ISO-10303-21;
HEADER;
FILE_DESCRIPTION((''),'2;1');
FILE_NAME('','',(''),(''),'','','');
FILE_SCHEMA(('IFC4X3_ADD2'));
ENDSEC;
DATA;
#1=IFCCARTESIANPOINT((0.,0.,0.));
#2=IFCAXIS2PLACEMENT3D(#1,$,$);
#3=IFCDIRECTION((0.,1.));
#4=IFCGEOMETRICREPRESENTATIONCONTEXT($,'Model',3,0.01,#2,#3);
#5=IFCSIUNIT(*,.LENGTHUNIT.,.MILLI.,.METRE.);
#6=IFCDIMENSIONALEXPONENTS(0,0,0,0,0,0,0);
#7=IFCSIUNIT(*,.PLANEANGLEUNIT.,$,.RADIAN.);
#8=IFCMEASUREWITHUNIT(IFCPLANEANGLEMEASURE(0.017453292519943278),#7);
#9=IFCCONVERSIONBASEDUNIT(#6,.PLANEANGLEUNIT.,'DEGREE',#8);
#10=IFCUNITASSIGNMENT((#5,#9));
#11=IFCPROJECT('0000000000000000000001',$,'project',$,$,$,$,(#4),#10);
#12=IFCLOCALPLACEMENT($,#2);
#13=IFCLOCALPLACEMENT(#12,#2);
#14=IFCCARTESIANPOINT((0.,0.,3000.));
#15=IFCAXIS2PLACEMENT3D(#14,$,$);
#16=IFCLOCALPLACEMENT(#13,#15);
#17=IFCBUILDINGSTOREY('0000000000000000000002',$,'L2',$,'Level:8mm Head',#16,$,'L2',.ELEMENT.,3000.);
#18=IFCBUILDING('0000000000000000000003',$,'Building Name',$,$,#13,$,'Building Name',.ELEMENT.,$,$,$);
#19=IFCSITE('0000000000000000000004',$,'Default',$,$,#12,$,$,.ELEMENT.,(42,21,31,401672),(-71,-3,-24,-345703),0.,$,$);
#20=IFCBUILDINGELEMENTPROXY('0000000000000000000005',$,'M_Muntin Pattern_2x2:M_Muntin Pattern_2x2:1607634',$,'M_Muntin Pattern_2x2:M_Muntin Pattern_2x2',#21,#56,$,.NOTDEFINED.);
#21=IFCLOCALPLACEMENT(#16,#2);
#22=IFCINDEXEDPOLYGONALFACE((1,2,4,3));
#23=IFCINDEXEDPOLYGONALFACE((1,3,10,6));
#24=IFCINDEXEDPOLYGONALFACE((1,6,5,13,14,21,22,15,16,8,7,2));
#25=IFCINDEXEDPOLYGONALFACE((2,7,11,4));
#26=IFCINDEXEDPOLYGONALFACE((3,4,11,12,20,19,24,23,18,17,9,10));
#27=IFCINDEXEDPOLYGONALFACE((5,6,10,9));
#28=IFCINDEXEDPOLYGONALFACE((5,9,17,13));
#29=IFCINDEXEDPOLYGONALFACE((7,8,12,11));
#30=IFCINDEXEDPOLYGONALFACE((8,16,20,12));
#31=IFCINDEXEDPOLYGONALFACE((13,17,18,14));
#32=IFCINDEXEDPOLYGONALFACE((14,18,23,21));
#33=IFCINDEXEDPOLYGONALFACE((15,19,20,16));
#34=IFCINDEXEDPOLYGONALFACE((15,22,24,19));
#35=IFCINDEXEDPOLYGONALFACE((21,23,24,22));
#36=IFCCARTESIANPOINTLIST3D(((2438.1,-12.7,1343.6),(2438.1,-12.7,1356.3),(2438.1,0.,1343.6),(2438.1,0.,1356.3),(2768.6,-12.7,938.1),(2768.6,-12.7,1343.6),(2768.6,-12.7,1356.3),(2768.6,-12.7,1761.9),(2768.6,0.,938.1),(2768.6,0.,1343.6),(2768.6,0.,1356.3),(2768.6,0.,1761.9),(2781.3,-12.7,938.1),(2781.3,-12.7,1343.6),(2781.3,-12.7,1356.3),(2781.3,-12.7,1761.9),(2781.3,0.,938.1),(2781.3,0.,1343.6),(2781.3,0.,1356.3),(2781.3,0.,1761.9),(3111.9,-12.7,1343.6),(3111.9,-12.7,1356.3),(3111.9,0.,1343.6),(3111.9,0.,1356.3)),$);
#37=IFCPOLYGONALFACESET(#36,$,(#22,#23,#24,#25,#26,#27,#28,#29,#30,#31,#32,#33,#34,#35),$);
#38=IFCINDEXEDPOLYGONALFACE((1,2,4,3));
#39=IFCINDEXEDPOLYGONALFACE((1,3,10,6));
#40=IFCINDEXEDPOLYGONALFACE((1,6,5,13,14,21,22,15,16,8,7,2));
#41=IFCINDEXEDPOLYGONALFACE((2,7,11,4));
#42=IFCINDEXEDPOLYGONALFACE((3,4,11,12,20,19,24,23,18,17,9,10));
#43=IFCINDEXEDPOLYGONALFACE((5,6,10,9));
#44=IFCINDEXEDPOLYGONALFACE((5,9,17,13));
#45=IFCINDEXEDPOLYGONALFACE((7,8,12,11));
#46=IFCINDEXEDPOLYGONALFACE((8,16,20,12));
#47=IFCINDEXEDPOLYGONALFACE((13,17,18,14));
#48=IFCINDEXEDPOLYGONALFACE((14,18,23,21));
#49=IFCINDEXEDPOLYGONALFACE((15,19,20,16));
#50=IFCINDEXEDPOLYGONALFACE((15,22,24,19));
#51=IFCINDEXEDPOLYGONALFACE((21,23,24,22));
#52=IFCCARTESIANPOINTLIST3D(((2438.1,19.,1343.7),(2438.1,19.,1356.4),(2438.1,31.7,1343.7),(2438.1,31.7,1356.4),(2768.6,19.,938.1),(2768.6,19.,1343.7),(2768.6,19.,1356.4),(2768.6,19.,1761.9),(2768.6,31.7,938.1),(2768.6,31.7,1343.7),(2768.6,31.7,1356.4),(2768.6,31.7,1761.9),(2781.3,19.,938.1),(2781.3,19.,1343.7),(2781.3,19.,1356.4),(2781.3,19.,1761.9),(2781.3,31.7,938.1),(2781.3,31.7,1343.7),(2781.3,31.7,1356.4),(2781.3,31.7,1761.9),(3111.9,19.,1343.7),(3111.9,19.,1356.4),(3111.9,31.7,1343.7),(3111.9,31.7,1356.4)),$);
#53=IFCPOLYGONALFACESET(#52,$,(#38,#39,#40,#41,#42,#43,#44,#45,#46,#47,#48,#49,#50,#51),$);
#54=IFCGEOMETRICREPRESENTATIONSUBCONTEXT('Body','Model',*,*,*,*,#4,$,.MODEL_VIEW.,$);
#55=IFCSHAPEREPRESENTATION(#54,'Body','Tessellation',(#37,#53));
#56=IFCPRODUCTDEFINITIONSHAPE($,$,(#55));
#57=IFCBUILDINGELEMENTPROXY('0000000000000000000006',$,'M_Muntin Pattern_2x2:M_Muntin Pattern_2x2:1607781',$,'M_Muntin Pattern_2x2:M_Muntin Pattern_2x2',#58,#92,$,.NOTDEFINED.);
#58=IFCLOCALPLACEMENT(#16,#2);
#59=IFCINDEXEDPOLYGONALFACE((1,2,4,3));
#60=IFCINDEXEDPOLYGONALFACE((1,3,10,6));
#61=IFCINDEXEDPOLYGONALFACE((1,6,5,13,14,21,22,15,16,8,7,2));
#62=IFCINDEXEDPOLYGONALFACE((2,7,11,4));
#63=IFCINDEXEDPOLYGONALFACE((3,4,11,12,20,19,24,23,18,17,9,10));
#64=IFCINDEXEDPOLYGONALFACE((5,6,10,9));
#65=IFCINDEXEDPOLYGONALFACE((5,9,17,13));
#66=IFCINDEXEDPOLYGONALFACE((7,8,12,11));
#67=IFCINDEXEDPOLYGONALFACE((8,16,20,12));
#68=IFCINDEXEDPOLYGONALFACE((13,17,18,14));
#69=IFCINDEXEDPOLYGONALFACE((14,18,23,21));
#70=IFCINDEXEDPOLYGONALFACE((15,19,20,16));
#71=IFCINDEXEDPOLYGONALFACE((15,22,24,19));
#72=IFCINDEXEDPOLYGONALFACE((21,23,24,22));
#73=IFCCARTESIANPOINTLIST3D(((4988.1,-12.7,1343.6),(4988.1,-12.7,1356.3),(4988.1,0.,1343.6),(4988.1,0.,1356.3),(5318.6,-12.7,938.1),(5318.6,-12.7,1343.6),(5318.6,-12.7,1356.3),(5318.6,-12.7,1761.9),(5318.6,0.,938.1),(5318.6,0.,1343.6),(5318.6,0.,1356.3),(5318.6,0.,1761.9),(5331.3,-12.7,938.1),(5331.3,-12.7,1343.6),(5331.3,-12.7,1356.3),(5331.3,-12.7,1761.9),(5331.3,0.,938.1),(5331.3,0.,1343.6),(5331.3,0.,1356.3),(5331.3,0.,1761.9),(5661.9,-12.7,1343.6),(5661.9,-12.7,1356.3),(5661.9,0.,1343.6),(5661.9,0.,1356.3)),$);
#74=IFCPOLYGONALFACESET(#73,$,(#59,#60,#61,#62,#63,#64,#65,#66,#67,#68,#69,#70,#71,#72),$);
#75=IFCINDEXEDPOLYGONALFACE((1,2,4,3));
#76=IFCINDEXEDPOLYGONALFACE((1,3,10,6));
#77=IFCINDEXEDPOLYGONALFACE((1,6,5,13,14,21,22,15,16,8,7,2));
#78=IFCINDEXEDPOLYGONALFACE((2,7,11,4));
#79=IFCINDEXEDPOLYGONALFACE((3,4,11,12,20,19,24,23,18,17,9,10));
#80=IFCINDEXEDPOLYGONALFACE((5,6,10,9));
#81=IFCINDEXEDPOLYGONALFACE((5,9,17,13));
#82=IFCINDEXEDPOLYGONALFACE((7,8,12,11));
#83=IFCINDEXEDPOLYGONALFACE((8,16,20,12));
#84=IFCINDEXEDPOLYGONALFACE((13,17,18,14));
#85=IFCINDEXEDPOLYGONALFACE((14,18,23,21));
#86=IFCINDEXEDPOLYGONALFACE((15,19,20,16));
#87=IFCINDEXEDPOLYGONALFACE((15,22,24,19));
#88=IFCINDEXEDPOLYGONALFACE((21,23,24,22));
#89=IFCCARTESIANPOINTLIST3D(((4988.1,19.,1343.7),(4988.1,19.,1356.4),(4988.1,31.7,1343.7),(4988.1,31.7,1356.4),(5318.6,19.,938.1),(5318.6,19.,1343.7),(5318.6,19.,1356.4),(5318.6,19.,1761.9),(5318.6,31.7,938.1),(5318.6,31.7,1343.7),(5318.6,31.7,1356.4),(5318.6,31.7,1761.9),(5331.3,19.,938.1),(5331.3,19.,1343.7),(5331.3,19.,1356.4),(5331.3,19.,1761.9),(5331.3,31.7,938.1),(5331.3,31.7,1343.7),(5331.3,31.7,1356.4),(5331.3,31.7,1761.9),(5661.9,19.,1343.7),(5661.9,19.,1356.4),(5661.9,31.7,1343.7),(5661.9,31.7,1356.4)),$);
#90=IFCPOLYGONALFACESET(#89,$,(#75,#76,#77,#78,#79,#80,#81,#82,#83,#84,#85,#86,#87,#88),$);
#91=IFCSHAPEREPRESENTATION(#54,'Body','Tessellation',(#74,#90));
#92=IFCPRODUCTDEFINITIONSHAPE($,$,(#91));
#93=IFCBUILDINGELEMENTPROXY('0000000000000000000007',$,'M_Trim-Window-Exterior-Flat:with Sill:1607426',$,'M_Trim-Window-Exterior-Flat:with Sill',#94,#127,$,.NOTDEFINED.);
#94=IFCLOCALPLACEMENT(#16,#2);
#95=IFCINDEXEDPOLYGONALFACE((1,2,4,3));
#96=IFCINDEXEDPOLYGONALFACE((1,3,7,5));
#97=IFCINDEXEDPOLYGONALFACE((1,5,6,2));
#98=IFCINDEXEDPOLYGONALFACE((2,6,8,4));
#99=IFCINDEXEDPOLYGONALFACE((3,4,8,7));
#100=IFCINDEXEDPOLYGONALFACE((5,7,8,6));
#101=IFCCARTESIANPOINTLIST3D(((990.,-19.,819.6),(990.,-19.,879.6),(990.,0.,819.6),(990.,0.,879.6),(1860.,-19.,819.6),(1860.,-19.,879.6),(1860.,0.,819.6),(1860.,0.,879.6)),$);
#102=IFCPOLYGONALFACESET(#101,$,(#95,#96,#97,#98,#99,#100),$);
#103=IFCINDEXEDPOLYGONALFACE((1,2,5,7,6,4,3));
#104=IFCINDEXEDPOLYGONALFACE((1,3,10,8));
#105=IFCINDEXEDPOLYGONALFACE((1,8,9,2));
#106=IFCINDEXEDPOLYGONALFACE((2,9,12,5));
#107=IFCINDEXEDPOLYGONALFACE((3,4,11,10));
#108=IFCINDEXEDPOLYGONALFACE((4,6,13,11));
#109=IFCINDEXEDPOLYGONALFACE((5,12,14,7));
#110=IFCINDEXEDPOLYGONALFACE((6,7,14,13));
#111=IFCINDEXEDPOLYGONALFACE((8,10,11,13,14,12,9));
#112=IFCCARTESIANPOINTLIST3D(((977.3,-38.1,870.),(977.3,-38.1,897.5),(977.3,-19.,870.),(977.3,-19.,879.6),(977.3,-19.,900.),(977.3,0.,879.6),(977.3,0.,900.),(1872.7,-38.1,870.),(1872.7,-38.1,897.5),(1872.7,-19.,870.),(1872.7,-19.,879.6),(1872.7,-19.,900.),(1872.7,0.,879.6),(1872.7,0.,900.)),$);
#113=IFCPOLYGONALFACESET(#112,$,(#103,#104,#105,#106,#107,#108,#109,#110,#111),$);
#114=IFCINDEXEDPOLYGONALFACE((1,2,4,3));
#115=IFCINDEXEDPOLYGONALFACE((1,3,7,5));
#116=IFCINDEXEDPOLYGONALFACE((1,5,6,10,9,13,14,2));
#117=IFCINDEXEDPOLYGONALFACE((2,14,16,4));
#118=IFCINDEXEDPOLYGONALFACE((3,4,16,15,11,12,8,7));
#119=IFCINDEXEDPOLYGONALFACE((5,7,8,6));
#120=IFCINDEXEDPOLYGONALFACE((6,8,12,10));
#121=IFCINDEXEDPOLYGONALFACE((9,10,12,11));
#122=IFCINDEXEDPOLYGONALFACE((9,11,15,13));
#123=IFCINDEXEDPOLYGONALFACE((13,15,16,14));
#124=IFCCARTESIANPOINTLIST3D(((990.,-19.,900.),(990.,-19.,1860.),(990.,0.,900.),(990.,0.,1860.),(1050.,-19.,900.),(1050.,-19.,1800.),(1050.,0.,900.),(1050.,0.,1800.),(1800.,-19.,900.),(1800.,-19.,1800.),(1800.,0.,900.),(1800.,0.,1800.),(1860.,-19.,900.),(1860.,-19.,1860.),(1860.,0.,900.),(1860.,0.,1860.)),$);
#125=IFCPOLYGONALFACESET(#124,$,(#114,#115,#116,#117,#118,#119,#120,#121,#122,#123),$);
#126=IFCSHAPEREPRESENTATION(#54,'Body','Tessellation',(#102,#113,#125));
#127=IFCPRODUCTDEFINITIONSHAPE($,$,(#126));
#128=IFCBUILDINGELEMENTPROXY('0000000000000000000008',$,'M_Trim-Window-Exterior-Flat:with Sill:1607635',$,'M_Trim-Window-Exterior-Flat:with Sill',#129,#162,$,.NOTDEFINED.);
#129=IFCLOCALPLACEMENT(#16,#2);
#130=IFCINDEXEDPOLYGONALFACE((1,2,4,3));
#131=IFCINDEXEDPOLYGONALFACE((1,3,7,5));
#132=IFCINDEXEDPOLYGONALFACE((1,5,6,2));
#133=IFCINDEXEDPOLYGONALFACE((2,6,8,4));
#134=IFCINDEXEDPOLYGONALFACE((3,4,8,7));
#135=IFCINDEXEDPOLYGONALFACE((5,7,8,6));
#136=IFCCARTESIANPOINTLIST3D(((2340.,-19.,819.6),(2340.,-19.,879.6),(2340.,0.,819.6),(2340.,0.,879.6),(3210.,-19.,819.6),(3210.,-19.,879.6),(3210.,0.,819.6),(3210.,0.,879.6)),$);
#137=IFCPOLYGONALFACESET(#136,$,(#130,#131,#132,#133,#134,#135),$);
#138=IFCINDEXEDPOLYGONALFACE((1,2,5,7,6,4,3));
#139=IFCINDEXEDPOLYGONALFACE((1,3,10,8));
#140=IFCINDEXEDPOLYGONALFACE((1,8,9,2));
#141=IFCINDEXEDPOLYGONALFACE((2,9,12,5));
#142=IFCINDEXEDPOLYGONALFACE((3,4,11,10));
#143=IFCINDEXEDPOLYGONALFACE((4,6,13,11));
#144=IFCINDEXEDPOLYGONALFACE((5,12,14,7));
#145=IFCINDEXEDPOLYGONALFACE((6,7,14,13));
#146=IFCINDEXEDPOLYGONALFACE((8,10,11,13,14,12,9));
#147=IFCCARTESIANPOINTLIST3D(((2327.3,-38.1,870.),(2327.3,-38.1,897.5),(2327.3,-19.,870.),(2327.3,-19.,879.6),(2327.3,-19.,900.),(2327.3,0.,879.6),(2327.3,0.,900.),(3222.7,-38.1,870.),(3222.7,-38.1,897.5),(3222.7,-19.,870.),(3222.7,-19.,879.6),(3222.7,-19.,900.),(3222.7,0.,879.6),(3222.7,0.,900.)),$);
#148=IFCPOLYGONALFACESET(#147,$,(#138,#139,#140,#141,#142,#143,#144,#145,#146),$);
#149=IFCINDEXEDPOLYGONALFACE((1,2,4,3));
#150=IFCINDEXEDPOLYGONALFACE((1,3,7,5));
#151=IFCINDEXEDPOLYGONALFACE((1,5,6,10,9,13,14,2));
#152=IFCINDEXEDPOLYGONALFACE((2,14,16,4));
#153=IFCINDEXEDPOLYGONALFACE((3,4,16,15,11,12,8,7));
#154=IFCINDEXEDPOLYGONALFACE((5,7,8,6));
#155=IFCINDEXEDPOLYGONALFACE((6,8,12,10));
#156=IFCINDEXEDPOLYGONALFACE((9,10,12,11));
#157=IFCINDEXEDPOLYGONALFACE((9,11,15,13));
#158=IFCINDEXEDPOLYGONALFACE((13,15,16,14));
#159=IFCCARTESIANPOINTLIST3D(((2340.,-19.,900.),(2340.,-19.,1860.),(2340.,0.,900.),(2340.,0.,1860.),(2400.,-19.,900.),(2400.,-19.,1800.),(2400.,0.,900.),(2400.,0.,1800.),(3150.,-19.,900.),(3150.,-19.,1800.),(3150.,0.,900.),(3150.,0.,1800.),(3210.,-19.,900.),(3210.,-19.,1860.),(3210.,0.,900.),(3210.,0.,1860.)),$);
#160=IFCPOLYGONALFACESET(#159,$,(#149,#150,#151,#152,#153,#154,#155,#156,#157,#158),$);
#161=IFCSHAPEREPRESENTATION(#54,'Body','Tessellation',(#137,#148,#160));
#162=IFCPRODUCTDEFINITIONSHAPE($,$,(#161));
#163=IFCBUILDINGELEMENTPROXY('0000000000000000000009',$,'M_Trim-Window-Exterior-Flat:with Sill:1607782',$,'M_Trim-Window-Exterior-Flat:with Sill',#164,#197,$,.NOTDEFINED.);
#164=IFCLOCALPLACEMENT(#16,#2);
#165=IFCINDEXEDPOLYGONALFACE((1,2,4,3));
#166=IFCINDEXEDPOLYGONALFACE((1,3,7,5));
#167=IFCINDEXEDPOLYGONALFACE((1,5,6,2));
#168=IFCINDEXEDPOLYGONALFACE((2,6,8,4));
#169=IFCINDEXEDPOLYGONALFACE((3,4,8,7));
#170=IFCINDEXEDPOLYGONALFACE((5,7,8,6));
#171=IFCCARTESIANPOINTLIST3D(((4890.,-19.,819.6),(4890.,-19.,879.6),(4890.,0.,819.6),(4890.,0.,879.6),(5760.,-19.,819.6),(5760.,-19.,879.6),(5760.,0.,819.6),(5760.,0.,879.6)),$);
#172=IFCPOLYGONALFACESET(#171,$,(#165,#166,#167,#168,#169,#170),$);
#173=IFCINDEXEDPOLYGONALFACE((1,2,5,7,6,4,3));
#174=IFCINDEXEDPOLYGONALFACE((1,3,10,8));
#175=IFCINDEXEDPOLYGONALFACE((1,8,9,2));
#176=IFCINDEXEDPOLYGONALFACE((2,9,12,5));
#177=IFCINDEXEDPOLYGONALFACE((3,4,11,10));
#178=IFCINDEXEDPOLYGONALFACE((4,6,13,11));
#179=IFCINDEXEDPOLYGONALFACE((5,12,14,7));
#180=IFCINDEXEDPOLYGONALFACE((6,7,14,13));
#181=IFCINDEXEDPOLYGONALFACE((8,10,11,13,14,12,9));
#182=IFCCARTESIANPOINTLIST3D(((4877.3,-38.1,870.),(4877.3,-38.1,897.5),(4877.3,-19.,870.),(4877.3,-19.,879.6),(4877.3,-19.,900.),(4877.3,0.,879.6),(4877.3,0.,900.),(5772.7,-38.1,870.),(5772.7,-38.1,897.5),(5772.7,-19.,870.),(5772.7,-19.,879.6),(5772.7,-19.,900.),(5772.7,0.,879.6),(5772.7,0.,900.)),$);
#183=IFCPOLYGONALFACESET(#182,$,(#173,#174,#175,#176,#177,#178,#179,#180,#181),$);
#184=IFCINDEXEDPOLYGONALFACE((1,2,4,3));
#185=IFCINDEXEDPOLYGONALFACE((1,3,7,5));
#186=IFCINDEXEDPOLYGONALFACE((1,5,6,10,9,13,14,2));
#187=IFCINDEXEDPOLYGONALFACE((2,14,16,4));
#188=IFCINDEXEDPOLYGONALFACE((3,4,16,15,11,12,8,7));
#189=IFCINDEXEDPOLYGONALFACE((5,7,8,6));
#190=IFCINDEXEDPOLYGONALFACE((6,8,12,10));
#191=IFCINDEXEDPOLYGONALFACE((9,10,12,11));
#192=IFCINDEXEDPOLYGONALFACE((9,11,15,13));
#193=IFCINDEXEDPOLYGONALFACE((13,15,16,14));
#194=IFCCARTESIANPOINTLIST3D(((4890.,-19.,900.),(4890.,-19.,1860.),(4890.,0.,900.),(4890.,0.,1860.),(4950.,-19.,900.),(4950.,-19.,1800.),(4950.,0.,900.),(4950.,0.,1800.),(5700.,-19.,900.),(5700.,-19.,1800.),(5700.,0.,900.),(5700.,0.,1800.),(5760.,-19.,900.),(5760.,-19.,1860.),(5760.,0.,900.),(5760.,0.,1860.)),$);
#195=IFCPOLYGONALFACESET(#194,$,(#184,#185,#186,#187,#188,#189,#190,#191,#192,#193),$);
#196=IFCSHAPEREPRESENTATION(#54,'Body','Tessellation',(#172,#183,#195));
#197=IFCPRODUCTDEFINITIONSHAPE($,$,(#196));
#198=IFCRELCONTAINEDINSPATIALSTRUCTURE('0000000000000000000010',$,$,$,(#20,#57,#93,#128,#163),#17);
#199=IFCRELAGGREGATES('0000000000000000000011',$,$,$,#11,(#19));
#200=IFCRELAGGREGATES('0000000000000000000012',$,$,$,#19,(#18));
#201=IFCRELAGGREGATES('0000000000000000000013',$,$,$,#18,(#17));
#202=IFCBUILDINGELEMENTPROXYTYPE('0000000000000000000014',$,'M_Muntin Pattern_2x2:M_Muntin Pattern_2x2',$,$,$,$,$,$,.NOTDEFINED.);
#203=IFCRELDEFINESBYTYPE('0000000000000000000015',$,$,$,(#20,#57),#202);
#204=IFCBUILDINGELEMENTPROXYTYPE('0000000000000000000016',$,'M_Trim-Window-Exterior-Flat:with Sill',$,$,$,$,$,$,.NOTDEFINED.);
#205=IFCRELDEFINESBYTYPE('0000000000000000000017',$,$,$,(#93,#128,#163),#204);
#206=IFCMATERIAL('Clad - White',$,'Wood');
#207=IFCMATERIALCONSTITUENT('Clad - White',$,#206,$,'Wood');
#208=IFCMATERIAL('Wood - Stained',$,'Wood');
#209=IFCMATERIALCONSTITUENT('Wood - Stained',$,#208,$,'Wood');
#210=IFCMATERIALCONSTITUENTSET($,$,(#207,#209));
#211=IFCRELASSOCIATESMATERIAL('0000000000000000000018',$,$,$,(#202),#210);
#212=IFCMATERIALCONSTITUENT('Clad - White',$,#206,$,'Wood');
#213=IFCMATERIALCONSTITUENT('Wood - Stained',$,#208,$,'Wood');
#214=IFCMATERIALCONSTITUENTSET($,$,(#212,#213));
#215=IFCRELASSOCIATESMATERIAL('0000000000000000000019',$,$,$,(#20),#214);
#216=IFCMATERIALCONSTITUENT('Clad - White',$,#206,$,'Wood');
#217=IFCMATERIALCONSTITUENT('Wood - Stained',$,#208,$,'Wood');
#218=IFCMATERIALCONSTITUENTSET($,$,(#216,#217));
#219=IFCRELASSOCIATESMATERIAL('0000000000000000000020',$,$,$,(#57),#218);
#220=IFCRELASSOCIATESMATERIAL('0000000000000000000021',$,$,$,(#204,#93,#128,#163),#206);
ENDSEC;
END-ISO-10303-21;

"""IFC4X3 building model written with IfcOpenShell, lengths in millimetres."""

from ifc_helpers import new_model, entity, si_unit, converted_unit, direction, frame, frame_2d, origin, place, context, subcontext, project, spatial, polyline, rectangle, outline, extrude, source, transform, mapped, material, constituent, constituent_set, type_object, type_shapes, element, save


model = new_model("IFC4X3")

# Units and contexts
model_context = context("Model", 3, precision=0.01, world=origin(), true_north=direction((0.0, 1.0)))
body_context = subcontext(model_context, "Body", "Model", "MODEL_VIEW")
ifc_project = project(units=[si_unit("LENGTHUNIT", "METRE", prefix="MILLI"), converted_unit("PLANEANGLEUNIT", "DEGREE", entity("IfcPlaneAngleMeasure", 0.017453292519943278), si_unit("PLANEANGLEUNIT", "RADIAN"), dimensions=[0, 0, 0, 0, 0, 0, 0])], contexts=[model_context])

# Site, building, storey
site_placement = place(None, origin())
site = spatial("IfcSite", under=ifc_project, at=site_placement, Name="Default", CompositionType="ELEMENT", RefLatitude=(42, 21, 31, 401672), RefLongitude=(-71, -3, -24, -345703), RefElevation=0.0)
building_placement = place(site_placement, origin())
building = spatial("IfcBuilding", under=site, at=building_placement, Name="Building Name", LongName="Building Name", CompositionType="ELEMENT")
storey_placement = place(building_placement, frame((0.0, 0.0, 3000.0)))
storey = spatial("IfcBuildingStorey", under=building, at=storey_placement, Name="L2", ObjectType="Level:8mm Head", LongName="L2", CompositionType="ELEMENT", Elevation=3000.0)

# Building element proxies
ifc_material_1 = material(Name="Clad - White", Category="Wood")
ifc_material_2 = material(Name="Wood - Stained", Category="Wood")
ifc_constituent_1 = constituent(ifc_material_1, Name="Clad - White", Category="Wood")
ifc_constituent_2 = constituent(ifc_material_2, Name="Wood - Stained", Category="Wood")
ifc_constituent_set_1 = constituent_set(constituents=[ifc_constituent_1, ifc_constituent_2])
building_element_proxy_type_1 = type_object("IfcBuildingElementProxyType", Name="M_Muntin Pattern_2x2:M_Muntin Pattern_2x2", PredefinedType="NOTDEFINED", material=ifc_constituent_set_1)
shared_shape_1 = source(origin(), body_context, "Body", "SweptSolid", [
    extrude(outline(polyline([(6.4, -6.4), (411.9, -6.4), (411.9, 6.3), (6.4, 6.3), (6.4, 336.9), (-6.3, 336.9), (-6.3, 6.3), (-411.9, 6.3), (-411.9, -6.4), (-6.3, -6.4), (-6.3, -336.9), (6.4, -336.9), (6.4, -6.4)])), frame((0.0, -22.2, 411.9), z_axis=(0.0, 1.0, 0.0), x_axis=(0.0, 0.0, 1.0)), (0.0, 0.0, 1.0), 12.7),
    extrude(outline(polyline([(6.4, -6.4), (411.9, -6.4), (411.9, 6.3), (6.4, 6.3), (6.4, 336.9), (-6.3, 336.9), (-6.3, 6.3), (-411.9, 6.3), (-411.9, -6.4), (-6.3, -6.4), (-6.3, -336.9), (6.4, -336.9), (6.4, -6.4)])), frame((0.0, 9.5, 411.9), z_axis=(0.0, 1.0, 0.0), x_axis=(0.0, 0.0, 1.0)), (0.0, 0.0, 1.0), 12.7),
])
type_shapes(building_element_proxy_type_1, [shared_shape_1])
ifc_constituent_3 = constituent(ifc_material_1, Name="Clad - White", Category="Wood")
ifc_constituent_4 = constituent(ifc_material_2, Name="Wood - Stained", Category="Wood")
ifc_constituent_set_2 = constituent_set(constituents=[ifc_constituent_3, ifc_constituent_4])
proxy_1_placement = place(storey_placement, frame((2775.0, 9.5, 938.1)))
element("IfcBuildingElementProxy", 1, at=proxy_1_placement, inside=storey, type_object=building_element_proxy_type_1, material=ifc_constituent_set_2, Name="M_Muntin Pattern_2x2:M_Muntin Pattern_2x2:1607634", ObjectType="M_Muntin Pattern_2x2:M_Muntin Pattern_2x2", PredefinedType="NOTDEFINED", context=body_context, shape_type="MappedRepresentation", body=[
    mapped(shared_shape_1, transform((0.0, 0.0, 0.0), scale=1.0)),
])
ifc_constituent_5 = constituent(ifc_material_1, Name="Clad - White", Category="Wood")
ifc_constituent_6 = constituent(ifc_material_2, Name="Wood - Stained", Category="Wood")
ifc_constituent_set_3 = constituent_set(constituents=[ifc_constituent_5, ifc_constituent_6])
proxy_2_placement = place(storey_placement, frame((5325.0, 9.5, 938.1)))
element("IfcBuildingElementProxy", 2, at=proxy_2_placement, inside=storey, type_object=building_element_proxy_type_1, material=ifc_constituent_set_3, Name="M_Muntin Pattern_2x2:M_Muntin Pattern_2x2:1607781", ObjectType="M_Muntin Pattern_2x2:M_Muntin Pattern_2x2", PredefinedType="NOTDEFINED", context=body_context, shape_type="MappedRepresentation", body=[
    mapped(shared_shape_1, transform((0.0, 0.0, 0.0), scale=1.0)),
])
building_element_proxy_type_2 = type_object("IfcBuildingElementProxyType", Name="M_Trim-Window-Exterior-Flat:with Sill", PredefinedType="NOTDEFINED", material=ifc_material_1)
shared_shape_2 = source(origin(), body_context, "Body", "SweptSolid", [
    extrude(rectangle(XDim=870.0, YDim=60.0, at=frame_2d((0.0, 0.0), x_axis=(1.0, 0.0))), frame((0.0, -950.4, 0.0), z_axis=(0.0, 0.0, 1.0), x_axis=(-1.0, 0.0, 0.0)), (0.0, 0.0, 1.0), 19.0),
    extrude(outline(polyline([(-19.0, -15.2), (0.0, -15.2), (0.0, -5.7), (19.0, -5.7), (19.0, 14.8), (0.0, 14.8), (-19.0, 12.3), (-19.0, -15.2)])), frame((-447.7, -914.8, 19.0), z_axis=(1.0, 0.0, 0.0), x_axis=(0.0, 0.0, -1.0)), (0.0, 0.0, 1.0), 895.4),
    extrude(outline(polyline([(-495.0, -435.0), (465.0, -435.0), (465.0, -375.0), (-435.0, -375.0), (-435.0, 375.0), (465.0, 375.0), (465.0, 435.0), (-495.0, 435.0), (-495.0, -435.0)])), frame((0.0, -435.0, 0.0), z_axis=(0.0, 0.0, 1.0), x_axis=(0.0, -1.0, 0.0)), (0.0, 0.0, 1.0), 19.0),
])
type_shapes(building_element_proxy_type_2, [shared_shape_2])
for number, where, z_axis, x_axis, name in (
    (3, (1425.0, 0.0, 1800.0), (0.0, -1.0, 0.0), (1.0, 0.0, 0.0), "M_Trim-Window-Exterior-Flat:with Sill:1607426"),
    (4, (2775.0, 0.0, 1800.0), (0.0, -1.0, 0.0), (1.0, 0.0, 0.0), "M_Trim-Window-Exterior-Flat:with Sill:1607635"),
    (5, (5325.0, 0.0, 1800.0), (0.0, -1.0, 0.0), (1.0, 0.0, 0.0), "M_Trim-Window-Exterior-Flat:with Sill:1607782"),
):
    element("IfcBuildingElementProxy", number, at=place(storey_placement, frame(where, z_axis=z_axis, x_axis=x_axis)), inside=storey, type_object=building_element_proxy_type_2, material=ifc_material_1, Name=name, ObjectType="M_Trim-Window-Exterior-Flat:with Sill", PredefinedType="NOTDEFINED", context=body_context, shape_type="MappedRepresentation", body=[
        mapped(shared_shape_2, transform((0.0, 0.0, 0.0), scale=1.0)),
    ])

save(model, "model.ifc")
